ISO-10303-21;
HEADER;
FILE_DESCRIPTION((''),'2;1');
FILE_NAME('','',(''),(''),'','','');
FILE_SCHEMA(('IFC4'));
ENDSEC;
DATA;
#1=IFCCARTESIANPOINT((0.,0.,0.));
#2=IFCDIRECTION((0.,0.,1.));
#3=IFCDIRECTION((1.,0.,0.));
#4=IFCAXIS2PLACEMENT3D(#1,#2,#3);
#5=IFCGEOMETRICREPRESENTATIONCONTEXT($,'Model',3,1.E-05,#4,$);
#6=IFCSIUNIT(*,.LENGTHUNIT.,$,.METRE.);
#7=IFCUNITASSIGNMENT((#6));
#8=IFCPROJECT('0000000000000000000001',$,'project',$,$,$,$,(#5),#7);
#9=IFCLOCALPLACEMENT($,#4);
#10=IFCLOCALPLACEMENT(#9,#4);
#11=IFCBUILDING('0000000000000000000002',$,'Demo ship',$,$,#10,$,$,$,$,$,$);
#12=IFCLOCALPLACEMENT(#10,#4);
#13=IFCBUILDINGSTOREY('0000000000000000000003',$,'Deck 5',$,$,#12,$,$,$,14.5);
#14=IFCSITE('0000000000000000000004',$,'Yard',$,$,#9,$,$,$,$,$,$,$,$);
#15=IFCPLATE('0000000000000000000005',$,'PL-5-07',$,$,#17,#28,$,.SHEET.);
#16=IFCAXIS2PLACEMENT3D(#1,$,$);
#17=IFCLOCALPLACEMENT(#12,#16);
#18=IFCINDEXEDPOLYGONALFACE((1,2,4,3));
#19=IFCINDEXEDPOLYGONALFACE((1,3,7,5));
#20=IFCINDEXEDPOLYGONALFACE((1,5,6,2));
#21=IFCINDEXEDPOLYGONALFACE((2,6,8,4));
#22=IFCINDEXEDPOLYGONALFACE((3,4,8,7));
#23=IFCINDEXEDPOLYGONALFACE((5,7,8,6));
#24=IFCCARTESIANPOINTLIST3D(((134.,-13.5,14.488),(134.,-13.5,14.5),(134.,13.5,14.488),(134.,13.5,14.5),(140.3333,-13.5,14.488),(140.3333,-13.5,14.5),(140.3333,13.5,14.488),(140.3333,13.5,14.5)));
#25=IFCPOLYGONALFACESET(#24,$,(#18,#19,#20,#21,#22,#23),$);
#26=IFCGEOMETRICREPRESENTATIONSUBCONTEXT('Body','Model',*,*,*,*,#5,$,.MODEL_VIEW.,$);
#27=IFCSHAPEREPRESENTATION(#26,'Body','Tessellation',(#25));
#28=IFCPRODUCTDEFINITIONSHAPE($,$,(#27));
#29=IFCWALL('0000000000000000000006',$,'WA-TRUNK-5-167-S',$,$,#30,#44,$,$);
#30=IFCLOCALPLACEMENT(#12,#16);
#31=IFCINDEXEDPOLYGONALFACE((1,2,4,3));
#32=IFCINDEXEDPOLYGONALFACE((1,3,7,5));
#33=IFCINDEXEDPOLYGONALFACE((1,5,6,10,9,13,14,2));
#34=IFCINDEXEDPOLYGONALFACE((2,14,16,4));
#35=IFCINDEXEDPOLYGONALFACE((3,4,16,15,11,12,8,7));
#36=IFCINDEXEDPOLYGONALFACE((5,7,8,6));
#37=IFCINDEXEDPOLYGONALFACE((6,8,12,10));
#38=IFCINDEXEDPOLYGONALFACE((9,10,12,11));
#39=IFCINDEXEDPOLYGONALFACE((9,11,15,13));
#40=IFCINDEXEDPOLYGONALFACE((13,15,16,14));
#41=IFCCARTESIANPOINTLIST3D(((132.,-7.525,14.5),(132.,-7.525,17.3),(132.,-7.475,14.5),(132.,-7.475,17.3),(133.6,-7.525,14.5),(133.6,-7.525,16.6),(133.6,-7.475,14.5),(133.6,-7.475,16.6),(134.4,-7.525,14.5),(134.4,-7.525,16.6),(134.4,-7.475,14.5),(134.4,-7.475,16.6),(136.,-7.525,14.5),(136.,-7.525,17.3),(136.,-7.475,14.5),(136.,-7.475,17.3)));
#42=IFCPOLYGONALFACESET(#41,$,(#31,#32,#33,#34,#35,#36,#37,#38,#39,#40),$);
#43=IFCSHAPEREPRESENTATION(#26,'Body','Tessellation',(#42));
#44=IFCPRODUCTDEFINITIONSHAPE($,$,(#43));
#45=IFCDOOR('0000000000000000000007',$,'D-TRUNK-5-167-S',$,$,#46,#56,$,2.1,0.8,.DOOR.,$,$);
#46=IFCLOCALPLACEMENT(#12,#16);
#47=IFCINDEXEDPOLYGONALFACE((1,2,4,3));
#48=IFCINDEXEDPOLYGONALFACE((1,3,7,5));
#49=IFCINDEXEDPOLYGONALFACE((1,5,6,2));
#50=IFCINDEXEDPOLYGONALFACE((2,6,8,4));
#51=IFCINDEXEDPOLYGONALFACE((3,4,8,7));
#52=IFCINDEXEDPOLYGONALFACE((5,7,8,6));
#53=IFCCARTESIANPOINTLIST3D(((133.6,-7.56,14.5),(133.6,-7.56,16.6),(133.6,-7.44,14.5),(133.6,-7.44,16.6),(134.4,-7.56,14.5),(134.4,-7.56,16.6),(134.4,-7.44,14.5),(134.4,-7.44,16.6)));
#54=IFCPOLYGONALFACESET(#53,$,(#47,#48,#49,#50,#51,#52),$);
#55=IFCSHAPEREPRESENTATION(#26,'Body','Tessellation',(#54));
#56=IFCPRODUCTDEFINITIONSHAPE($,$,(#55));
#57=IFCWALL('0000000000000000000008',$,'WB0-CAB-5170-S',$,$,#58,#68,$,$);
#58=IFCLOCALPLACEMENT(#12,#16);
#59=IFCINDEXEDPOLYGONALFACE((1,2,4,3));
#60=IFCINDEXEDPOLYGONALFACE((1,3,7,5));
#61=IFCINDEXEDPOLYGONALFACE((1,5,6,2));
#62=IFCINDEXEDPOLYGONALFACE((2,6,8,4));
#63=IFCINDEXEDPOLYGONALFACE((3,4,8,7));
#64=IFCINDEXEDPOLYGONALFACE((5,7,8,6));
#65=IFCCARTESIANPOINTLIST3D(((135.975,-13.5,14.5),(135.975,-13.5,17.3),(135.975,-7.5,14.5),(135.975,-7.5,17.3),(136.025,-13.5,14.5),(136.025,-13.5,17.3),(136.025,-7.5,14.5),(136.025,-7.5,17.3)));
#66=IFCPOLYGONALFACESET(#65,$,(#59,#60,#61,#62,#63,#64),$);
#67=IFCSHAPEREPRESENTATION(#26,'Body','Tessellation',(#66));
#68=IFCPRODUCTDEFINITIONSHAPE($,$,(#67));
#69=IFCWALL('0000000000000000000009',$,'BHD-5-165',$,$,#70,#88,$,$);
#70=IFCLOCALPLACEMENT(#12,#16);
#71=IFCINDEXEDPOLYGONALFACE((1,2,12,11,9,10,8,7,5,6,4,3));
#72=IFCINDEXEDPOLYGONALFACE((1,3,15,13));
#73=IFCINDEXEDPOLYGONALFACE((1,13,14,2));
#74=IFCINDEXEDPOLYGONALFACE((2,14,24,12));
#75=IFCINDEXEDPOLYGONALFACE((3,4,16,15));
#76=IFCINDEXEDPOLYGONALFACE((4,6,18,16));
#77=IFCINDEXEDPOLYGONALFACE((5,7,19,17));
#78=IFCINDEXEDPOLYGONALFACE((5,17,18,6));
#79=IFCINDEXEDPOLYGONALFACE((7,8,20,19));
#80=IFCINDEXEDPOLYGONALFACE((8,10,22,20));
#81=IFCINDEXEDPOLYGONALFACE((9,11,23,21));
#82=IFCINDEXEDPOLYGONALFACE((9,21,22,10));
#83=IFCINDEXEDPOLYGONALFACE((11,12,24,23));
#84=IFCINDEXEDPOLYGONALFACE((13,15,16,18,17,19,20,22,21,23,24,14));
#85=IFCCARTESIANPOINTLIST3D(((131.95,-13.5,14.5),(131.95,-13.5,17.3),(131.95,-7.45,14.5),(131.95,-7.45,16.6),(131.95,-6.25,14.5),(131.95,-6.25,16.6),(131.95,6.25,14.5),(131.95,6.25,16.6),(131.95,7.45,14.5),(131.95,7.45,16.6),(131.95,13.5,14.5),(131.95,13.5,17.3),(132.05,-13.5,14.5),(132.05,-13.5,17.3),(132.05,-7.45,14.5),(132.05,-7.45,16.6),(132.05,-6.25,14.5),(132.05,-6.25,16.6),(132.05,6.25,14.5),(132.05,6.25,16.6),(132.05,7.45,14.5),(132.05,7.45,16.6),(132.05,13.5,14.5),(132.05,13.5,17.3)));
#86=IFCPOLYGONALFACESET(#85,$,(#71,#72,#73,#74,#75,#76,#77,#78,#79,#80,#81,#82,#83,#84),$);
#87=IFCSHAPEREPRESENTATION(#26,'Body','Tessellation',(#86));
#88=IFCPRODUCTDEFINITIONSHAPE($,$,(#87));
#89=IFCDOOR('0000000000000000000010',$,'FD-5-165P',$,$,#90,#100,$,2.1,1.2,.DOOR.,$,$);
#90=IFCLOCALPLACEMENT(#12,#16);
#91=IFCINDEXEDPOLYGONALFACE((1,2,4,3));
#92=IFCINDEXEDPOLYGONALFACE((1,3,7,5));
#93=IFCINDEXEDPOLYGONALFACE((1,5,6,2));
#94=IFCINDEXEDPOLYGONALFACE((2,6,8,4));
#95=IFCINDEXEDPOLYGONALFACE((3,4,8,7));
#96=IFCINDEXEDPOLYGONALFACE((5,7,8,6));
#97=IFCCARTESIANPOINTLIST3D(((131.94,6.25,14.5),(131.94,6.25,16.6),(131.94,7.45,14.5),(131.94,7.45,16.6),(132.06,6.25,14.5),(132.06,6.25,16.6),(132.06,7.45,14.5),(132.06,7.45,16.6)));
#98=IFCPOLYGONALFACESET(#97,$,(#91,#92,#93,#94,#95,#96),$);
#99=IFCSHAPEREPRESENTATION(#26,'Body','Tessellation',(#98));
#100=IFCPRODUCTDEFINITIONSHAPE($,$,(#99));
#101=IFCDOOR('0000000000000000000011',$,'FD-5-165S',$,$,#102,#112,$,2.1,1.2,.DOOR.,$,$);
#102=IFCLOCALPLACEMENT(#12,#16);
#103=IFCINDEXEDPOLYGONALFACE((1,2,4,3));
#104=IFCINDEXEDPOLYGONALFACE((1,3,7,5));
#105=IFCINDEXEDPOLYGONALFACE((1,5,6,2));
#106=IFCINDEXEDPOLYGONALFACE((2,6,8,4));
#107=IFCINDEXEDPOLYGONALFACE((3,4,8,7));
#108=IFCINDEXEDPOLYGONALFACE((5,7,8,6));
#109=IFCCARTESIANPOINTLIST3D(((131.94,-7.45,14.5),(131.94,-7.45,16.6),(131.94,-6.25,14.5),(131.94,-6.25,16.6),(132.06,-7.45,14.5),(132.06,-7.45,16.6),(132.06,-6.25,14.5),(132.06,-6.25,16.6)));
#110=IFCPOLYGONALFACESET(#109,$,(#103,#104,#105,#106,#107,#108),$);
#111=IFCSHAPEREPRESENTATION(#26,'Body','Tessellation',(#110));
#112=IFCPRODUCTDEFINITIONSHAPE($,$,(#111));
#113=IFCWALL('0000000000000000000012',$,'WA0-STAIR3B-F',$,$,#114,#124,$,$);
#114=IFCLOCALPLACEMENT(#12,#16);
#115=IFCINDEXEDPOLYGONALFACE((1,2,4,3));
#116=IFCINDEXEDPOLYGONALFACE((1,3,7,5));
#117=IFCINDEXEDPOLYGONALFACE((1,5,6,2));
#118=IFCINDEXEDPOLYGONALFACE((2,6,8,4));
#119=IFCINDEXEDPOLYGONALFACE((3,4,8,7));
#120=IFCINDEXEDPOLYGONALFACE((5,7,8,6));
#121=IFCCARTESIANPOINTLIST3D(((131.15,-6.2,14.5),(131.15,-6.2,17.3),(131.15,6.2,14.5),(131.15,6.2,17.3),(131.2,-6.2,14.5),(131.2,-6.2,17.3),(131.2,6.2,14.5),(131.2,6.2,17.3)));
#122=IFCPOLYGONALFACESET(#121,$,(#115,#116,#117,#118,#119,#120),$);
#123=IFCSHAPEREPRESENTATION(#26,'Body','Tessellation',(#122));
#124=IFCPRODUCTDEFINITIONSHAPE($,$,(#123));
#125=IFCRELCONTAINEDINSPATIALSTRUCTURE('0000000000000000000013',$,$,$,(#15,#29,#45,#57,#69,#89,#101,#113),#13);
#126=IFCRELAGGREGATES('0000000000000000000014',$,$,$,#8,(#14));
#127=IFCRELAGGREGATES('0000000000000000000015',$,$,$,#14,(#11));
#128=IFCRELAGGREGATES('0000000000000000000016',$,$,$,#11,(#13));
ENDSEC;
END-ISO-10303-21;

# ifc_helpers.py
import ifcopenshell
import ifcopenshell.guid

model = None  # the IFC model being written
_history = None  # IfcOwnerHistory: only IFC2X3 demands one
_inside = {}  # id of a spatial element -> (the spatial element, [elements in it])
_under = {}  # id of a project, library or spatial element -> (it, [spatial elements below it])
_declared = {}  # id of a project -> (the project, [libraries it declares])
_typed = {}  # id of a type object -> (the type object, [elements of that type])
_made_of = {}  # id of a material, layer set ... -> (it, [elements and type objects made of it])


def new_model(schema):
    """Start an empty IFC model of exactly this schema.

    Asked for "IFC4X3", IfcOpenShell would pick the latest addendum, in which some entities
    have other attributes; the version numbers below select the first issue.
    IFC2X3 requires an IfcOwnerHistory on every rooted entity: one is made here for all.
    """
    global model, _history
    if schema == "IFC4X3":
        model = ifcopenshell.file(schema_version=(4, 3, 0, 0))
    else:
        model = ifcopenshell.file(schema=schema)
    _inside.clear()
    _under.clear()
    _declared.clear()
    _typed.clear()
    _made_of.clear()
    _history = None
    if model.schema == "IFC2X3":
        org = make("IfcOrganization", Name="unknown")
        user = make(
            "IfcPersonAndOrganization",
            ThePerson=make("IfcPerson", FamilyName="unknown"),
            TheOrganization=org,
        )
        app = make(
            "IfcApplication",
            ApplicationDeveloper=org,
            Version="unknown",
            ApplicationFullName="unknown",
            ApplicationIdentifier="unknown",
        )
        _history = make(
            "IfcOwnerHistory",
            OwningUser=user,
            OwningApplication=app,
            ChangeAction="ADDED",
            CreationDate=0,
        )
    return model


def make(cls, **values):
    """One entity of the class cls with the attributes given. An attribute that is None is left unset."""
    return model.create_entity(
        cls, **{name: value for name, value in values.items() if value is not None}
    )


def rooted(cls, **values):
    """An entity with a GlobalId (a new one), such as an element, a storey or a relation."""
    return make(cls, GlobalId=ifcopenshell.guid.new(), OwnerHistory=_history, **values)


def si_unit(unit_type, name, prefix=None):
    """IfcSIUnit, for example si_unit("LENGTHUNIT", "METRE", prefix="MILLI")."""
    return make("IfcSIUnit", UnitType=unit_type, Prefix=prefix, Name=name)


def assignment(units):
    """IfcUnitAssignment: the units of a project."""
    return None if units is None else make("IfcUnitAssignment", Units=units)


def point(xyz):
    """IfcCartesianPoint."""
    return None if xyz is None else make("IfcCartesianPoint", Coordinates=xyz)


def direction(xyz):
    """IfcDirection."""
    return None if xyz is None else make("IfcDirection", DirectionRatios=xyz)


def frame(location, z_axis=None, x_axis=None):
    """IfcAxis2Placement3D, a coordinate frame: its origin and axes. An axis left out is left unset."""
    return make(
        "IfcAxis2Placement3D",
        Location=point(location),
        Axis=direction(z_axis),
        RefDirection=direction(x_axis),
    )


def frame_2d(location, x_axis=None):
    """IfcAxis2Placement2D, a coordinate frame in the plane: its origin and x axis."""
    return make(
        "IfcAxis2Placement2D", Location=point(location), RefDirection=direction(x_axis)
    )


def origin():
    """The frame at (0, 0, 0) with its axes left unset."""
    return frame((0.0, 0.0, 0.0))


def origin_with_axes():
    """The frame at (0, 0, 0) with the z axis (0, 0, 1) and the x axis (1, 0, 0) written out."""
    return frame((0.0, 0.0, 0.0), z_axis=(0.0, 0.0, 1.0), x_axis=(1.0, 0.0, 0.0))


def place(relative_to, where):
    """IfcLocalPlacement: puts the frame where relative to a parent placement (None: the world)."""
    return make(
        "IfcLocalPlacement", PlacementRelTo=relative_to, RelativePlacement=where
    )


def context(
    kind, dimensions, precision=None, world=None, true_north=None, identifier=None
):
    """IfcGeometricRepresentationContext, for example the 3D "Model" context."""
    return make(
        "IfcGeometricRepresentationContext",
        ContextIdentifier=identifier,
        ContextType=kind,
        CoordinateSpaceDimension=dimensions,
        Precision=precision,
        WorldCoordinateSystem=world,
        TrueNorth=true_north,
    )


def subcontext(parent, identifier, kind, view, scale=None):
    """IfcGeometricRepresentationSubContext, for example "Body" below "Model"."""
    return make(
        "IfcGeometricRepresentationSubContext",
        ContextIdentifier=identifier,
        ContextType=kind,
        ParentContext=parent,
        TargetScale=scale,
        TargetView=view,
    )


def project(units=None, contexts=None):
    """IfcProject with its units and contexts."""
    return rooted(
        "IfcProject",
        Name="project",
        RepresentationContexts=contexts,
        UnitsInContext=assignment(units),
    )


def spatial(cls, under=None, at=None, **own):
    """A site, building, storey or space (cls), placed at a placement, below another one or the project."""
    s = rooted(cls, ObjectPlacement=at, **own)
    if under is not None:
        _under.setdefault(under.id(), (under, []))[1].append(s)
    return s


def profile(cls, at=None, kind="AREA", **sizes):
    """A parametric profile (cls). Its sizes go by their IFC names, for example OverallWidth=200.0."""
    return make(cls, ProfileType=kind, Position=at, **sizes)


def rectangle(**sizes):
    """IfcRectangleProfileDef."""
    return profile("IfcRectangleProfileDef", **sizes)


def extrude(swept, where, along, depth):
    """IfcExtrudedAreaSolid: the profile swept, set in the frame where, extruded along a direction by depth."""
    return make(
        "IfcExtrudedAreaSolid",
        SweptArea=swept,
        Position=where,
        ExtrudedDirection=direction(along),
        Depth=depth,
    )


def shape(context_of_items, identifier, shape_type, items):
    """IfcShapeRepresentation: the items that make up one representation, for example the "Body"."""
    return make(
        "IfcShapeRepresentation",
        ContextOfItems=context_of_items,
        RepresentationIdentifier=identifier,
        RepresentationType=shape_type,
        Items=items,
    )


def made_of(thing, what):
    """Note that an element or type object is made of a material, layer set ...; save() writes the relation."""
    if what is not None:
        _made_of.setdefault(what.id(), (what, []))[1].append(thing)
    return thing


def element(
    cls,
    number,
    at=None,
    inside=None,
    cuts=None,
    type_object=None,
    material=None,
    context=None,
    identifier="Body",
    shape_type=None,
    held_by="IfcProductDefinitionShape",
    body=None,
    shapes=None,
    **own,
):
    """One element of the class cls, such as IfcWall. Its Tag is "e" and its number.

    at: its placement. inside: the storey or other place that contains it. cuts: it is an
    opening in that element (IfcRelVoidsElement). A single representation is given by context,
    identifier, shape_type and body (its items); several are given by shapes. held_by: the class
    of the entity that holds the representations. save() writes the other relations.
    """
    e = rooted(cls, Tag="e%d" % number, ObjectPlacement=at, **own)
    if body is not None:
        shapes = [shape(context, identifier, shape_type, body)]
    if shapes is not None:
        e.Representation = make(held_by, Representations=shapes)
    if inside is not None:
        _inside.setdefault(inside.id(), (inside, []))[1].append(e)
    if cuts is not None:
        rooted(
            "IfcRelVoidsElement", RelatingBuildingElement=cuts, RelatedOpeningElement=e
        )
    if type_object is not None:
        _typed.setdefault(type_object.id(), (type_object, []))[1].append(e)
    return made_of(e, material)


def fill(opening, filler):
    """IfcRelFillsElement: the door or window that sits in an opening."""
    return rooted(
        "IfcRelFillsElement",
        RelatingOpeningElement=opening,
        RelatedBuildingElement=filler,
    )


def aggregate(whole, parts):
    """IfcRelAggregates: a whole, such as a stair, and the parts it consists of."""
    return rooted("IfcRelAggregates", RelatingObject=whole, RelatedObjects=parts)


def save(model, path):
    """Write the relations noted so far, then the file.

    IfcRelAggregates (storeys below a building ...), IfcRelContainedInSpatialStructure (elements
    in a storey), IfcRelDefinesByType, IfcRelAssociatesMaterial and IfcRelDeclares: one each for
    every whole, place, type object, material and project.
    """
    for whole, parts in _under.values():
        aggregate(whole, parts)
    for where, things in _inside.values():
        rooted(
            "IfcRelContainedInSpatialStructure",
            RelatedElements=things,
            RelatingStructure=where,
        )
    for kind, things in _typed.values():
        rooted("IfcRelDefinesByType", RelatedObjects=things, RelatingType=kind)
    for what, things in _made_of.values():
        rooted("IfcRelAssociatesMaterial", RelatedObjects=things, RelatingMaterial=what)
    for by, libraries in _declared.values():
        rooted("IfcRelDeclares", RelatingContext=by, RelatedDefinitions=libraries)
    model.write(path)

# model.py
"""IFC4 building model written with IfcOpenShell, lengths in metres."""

from ifc_helpers import new_model, si_unit, frame, frame_2d, origin, origin_with_axes, place, context, subcontext, project, spatial, rectangle, extrude, element, fill, save


model = new_model("IFC4")

# Units and contexts
model_context = context("Model", 3, precision=1e-05, world=origin_with_axes())
body_context = subcontext(model_context, "Body", "Model", "MODEL_VIEW")
ifc_project = project(units=[si_unit("LENGTHUNIT", "METRE")], contexts=[model_context])

# Site, building, storey
site_placement = place(None, origin_with_axes())
site = spatial("IfcSite", under=ifc_project, at=site_placement, Name="Yard")
building_placement = place(site_placement, origin_with_axes())
building = spatial("IfcBuilding", under=site, at=building_placement, Name="Demo ship")
storey_placement = place(building_placement, origin_with_axes())
storey = spatial("IfcBuildingStorey", under=building, at=storey_placement, Name="Deck 5", Elevation=14.5)

# Plate
plate_placement = place(storey_placement, frame((134.0, -13.5, 14.488), z_axis=(0.0, 0.0, 1.0), x_axis=(1.0, 0.0, 0.0)))
element("IfcPlate", 1, at=plate_placement, inside=storey, Name="PL-5-07", PredefinedType="SHEET", context=body_context, shape_type="SweptSolid", body=[
    extrude(rectangle(XDim=6.3333, YDim=27.0, at=frame_2d((3.1667, 13.5))), origin(), (0.0, 0.0, 1.0), 0.012),
])

# Wall, opening, door
wall_1_placement = place(storey_placement, frame((132.0, -7.525, 14.5), z_axis=(0.0, 0.0, 1.0), x_axis=(1.0, 0.0, 0.0)))
wall_1 = element("IfcWall", 2, at=wall_1_placement, inside=storey, Name="WA-TRUNK-5-167-S", context=body_context, shape_type="SweptSolid", body=[
    extrude(rectangle(XDim=4.0, YDim=0.05, at=frame_2d((2.0, 0.025))), origin(), (0.0, 0.0, 1.0), 2.8),
])
opening_1_placement = place(None, frame((133.6, -7.56, 14.5), z_axis=(0.0, 0.0, 1.0), x_axis=(1.0, 0.0, 0.0)))
opening_1 = element("IfcOpeningElement", 3, at=opening_1_placement, cuts=wall_1, context=body_context, shape_type="SweptSolid", body=[
    extrude(rectangle(XDim=0.8, YDim=0.12, at=frame_2d((0.4, 0.06))), origin(), (0.0, 0.0, 1.0), 2.1),
])
door_1_placement = place(storey_placement, frame((133.6, -7.56, 14.5), z_axis=(0.0, 0.0, 1.0), x_axis=(1.0, 0.0, 0.0)))
door_1 = element("IfcDoor", 4, at=door_1_placement, inside=storey, Name="D-TRUNK-5-167-S", OverallHeight=2.1, OverallWidth=0.8, PredefinedType="DOOR", context=body_context, shape_type="SweptSolid", body=[
    extrude(rectangle(XDim=0.8, YDim=0.12, at=frame_2d((0.4, 0.06))), origin(), (0.0, 0.0, 1.0), 2.1),
])
fill(opening_1, door_1)

# Wall
wall_2_placement = place(storey_placement, frame((135.975, -13.5, 14.5), z_axis=(0.0, 0.0, 1.0), x_axis=(1.0, 0.0, 0.0)))
element("IfcWall", 5, at=wall_2_placement, inside=storey, Name="WB0-CAB-5170-S", context=body_context, shape_type="SweptSolid", body=[
    extrude(rectangle(XDim=0.05, YDim=6.0, at=frame_2d((0.025, 3.0))), origin(), (0.0, 0.0, 1.0), 2.8),
])

# Wall, openings, doors
wall_3_placement = place(storey_placement, frame((131.95, -13.5, 14.5), z_axis=(0.0, 0.0, 1.0), x_axis=(1.0, 0.0, 0.0)))
wall_3 = element("IfcWall", 6, at=wall_3_placement, inside=storey, Name="BHD-5-165", context=body_context, shape_type="SweptSolid", body=[
    extrude(rectangle(XDim=0.1, YDim=27.0, at=frame_2d((0.05, 13.5))), origin(), (0.0, 0.0, 1.0), 2.8),
])
opening_2_placement = place(None, frame((131.94, 6.25, 14.5), z_axis=(0.0, 0.0, 1.0), x_axis=(1.0, 0.0, 0.0)))
opening_2 = element("IfcOpeningElement", 7, at=opening_2_placement, cuts=wall_3, context=body_context, shape_type="SweptSolid", body=[
    extrude(rectangle(XDim=0.12, YDim=1.2, at=frame_2d((0.06, 0.6))), origin(), (0.0, 0.0, 1.0), 2.1),
])
opening_3_placement = place(None, frame((131.94, -7.45, 14.5), z_axis=(0.0, 0.0, 1.0), x_axis=(1.0, 0.0, 0.0)))
opening_3 = element("IfcOpeningElement", 8, at=opening_3_placement, cuts=wall_3, context=body_context, shape_type="SweptSolid", body=[
    extrude(rectangle(XDim=0.12, YDim=1.2, at=frame_2d((0.06, 0.6))), origin(), (0.0, 0.0, 1.0), 2.1),
])
door_2_placement = place(storey_placement, frame((131.94, 6.25, 14.5), z_axis=(0.0, 0.0, 1.0), x_axis=(1.0, 0.0, 0.0)))
door_2 = element("IfcDoor", 9, at=door_2_placement, inside=storey, Name="FD-5-165P", OverallHeight=2.1, OverallWidth=1.2, PredefinedType="DOOR", context=body_context, shape_type="SweptSolid", body=[
    extrude(rectangle(XDim=0.12, YDim=1.2, at=frame_2d((0.06, 0.6))), origin(), (0.0, 0.0, 1.0), 2.1),
])
fill(opening_2, door_2)
door_3_placement = place(storey_placement, frame((131.94, -7.45, 14.5), z_axis=(0.0, 0.0, 1.0), x_axis=(1.0, 0.0, 0.0)))
door_3 = element("IfcDoor", 10, at=door_3_placement, inside=storey, Name="FD-5-165S", OverallHeight=2.1, OverallWidth=1.2, PredefinedType="DOOR", context=body_context, shape_type="SweptSolid", body=[
    extrude(rectangle(XDim=0.12, YDim=1.2, at=frame_2d((0.06, 0.6))), origin(), (0.0, 0.0, 1.0), 2.1),
])
fill(opening_3, door_3)

# Wall
wall_4_placement = place(storey_placement, frame((131.15, -6.2, 14.5), z_axis=(0.0, 0.0, 1.0), x_axis=(1.0, 0.0, 0.0)))
element("IfcWall", 11, at=wall_4_placement, inside=storey, Name="WA0-STAIR3B-F", context=body_context, shape_type="SweptSolid", body=[
    extrude(rectangle(XDim=0.05, YDim=12.4, at=frame_2d((0.025, 6.2))), origin(), (0.0, 0.0, 1.0), 2.8),
])

save(model, "model.ifc")
